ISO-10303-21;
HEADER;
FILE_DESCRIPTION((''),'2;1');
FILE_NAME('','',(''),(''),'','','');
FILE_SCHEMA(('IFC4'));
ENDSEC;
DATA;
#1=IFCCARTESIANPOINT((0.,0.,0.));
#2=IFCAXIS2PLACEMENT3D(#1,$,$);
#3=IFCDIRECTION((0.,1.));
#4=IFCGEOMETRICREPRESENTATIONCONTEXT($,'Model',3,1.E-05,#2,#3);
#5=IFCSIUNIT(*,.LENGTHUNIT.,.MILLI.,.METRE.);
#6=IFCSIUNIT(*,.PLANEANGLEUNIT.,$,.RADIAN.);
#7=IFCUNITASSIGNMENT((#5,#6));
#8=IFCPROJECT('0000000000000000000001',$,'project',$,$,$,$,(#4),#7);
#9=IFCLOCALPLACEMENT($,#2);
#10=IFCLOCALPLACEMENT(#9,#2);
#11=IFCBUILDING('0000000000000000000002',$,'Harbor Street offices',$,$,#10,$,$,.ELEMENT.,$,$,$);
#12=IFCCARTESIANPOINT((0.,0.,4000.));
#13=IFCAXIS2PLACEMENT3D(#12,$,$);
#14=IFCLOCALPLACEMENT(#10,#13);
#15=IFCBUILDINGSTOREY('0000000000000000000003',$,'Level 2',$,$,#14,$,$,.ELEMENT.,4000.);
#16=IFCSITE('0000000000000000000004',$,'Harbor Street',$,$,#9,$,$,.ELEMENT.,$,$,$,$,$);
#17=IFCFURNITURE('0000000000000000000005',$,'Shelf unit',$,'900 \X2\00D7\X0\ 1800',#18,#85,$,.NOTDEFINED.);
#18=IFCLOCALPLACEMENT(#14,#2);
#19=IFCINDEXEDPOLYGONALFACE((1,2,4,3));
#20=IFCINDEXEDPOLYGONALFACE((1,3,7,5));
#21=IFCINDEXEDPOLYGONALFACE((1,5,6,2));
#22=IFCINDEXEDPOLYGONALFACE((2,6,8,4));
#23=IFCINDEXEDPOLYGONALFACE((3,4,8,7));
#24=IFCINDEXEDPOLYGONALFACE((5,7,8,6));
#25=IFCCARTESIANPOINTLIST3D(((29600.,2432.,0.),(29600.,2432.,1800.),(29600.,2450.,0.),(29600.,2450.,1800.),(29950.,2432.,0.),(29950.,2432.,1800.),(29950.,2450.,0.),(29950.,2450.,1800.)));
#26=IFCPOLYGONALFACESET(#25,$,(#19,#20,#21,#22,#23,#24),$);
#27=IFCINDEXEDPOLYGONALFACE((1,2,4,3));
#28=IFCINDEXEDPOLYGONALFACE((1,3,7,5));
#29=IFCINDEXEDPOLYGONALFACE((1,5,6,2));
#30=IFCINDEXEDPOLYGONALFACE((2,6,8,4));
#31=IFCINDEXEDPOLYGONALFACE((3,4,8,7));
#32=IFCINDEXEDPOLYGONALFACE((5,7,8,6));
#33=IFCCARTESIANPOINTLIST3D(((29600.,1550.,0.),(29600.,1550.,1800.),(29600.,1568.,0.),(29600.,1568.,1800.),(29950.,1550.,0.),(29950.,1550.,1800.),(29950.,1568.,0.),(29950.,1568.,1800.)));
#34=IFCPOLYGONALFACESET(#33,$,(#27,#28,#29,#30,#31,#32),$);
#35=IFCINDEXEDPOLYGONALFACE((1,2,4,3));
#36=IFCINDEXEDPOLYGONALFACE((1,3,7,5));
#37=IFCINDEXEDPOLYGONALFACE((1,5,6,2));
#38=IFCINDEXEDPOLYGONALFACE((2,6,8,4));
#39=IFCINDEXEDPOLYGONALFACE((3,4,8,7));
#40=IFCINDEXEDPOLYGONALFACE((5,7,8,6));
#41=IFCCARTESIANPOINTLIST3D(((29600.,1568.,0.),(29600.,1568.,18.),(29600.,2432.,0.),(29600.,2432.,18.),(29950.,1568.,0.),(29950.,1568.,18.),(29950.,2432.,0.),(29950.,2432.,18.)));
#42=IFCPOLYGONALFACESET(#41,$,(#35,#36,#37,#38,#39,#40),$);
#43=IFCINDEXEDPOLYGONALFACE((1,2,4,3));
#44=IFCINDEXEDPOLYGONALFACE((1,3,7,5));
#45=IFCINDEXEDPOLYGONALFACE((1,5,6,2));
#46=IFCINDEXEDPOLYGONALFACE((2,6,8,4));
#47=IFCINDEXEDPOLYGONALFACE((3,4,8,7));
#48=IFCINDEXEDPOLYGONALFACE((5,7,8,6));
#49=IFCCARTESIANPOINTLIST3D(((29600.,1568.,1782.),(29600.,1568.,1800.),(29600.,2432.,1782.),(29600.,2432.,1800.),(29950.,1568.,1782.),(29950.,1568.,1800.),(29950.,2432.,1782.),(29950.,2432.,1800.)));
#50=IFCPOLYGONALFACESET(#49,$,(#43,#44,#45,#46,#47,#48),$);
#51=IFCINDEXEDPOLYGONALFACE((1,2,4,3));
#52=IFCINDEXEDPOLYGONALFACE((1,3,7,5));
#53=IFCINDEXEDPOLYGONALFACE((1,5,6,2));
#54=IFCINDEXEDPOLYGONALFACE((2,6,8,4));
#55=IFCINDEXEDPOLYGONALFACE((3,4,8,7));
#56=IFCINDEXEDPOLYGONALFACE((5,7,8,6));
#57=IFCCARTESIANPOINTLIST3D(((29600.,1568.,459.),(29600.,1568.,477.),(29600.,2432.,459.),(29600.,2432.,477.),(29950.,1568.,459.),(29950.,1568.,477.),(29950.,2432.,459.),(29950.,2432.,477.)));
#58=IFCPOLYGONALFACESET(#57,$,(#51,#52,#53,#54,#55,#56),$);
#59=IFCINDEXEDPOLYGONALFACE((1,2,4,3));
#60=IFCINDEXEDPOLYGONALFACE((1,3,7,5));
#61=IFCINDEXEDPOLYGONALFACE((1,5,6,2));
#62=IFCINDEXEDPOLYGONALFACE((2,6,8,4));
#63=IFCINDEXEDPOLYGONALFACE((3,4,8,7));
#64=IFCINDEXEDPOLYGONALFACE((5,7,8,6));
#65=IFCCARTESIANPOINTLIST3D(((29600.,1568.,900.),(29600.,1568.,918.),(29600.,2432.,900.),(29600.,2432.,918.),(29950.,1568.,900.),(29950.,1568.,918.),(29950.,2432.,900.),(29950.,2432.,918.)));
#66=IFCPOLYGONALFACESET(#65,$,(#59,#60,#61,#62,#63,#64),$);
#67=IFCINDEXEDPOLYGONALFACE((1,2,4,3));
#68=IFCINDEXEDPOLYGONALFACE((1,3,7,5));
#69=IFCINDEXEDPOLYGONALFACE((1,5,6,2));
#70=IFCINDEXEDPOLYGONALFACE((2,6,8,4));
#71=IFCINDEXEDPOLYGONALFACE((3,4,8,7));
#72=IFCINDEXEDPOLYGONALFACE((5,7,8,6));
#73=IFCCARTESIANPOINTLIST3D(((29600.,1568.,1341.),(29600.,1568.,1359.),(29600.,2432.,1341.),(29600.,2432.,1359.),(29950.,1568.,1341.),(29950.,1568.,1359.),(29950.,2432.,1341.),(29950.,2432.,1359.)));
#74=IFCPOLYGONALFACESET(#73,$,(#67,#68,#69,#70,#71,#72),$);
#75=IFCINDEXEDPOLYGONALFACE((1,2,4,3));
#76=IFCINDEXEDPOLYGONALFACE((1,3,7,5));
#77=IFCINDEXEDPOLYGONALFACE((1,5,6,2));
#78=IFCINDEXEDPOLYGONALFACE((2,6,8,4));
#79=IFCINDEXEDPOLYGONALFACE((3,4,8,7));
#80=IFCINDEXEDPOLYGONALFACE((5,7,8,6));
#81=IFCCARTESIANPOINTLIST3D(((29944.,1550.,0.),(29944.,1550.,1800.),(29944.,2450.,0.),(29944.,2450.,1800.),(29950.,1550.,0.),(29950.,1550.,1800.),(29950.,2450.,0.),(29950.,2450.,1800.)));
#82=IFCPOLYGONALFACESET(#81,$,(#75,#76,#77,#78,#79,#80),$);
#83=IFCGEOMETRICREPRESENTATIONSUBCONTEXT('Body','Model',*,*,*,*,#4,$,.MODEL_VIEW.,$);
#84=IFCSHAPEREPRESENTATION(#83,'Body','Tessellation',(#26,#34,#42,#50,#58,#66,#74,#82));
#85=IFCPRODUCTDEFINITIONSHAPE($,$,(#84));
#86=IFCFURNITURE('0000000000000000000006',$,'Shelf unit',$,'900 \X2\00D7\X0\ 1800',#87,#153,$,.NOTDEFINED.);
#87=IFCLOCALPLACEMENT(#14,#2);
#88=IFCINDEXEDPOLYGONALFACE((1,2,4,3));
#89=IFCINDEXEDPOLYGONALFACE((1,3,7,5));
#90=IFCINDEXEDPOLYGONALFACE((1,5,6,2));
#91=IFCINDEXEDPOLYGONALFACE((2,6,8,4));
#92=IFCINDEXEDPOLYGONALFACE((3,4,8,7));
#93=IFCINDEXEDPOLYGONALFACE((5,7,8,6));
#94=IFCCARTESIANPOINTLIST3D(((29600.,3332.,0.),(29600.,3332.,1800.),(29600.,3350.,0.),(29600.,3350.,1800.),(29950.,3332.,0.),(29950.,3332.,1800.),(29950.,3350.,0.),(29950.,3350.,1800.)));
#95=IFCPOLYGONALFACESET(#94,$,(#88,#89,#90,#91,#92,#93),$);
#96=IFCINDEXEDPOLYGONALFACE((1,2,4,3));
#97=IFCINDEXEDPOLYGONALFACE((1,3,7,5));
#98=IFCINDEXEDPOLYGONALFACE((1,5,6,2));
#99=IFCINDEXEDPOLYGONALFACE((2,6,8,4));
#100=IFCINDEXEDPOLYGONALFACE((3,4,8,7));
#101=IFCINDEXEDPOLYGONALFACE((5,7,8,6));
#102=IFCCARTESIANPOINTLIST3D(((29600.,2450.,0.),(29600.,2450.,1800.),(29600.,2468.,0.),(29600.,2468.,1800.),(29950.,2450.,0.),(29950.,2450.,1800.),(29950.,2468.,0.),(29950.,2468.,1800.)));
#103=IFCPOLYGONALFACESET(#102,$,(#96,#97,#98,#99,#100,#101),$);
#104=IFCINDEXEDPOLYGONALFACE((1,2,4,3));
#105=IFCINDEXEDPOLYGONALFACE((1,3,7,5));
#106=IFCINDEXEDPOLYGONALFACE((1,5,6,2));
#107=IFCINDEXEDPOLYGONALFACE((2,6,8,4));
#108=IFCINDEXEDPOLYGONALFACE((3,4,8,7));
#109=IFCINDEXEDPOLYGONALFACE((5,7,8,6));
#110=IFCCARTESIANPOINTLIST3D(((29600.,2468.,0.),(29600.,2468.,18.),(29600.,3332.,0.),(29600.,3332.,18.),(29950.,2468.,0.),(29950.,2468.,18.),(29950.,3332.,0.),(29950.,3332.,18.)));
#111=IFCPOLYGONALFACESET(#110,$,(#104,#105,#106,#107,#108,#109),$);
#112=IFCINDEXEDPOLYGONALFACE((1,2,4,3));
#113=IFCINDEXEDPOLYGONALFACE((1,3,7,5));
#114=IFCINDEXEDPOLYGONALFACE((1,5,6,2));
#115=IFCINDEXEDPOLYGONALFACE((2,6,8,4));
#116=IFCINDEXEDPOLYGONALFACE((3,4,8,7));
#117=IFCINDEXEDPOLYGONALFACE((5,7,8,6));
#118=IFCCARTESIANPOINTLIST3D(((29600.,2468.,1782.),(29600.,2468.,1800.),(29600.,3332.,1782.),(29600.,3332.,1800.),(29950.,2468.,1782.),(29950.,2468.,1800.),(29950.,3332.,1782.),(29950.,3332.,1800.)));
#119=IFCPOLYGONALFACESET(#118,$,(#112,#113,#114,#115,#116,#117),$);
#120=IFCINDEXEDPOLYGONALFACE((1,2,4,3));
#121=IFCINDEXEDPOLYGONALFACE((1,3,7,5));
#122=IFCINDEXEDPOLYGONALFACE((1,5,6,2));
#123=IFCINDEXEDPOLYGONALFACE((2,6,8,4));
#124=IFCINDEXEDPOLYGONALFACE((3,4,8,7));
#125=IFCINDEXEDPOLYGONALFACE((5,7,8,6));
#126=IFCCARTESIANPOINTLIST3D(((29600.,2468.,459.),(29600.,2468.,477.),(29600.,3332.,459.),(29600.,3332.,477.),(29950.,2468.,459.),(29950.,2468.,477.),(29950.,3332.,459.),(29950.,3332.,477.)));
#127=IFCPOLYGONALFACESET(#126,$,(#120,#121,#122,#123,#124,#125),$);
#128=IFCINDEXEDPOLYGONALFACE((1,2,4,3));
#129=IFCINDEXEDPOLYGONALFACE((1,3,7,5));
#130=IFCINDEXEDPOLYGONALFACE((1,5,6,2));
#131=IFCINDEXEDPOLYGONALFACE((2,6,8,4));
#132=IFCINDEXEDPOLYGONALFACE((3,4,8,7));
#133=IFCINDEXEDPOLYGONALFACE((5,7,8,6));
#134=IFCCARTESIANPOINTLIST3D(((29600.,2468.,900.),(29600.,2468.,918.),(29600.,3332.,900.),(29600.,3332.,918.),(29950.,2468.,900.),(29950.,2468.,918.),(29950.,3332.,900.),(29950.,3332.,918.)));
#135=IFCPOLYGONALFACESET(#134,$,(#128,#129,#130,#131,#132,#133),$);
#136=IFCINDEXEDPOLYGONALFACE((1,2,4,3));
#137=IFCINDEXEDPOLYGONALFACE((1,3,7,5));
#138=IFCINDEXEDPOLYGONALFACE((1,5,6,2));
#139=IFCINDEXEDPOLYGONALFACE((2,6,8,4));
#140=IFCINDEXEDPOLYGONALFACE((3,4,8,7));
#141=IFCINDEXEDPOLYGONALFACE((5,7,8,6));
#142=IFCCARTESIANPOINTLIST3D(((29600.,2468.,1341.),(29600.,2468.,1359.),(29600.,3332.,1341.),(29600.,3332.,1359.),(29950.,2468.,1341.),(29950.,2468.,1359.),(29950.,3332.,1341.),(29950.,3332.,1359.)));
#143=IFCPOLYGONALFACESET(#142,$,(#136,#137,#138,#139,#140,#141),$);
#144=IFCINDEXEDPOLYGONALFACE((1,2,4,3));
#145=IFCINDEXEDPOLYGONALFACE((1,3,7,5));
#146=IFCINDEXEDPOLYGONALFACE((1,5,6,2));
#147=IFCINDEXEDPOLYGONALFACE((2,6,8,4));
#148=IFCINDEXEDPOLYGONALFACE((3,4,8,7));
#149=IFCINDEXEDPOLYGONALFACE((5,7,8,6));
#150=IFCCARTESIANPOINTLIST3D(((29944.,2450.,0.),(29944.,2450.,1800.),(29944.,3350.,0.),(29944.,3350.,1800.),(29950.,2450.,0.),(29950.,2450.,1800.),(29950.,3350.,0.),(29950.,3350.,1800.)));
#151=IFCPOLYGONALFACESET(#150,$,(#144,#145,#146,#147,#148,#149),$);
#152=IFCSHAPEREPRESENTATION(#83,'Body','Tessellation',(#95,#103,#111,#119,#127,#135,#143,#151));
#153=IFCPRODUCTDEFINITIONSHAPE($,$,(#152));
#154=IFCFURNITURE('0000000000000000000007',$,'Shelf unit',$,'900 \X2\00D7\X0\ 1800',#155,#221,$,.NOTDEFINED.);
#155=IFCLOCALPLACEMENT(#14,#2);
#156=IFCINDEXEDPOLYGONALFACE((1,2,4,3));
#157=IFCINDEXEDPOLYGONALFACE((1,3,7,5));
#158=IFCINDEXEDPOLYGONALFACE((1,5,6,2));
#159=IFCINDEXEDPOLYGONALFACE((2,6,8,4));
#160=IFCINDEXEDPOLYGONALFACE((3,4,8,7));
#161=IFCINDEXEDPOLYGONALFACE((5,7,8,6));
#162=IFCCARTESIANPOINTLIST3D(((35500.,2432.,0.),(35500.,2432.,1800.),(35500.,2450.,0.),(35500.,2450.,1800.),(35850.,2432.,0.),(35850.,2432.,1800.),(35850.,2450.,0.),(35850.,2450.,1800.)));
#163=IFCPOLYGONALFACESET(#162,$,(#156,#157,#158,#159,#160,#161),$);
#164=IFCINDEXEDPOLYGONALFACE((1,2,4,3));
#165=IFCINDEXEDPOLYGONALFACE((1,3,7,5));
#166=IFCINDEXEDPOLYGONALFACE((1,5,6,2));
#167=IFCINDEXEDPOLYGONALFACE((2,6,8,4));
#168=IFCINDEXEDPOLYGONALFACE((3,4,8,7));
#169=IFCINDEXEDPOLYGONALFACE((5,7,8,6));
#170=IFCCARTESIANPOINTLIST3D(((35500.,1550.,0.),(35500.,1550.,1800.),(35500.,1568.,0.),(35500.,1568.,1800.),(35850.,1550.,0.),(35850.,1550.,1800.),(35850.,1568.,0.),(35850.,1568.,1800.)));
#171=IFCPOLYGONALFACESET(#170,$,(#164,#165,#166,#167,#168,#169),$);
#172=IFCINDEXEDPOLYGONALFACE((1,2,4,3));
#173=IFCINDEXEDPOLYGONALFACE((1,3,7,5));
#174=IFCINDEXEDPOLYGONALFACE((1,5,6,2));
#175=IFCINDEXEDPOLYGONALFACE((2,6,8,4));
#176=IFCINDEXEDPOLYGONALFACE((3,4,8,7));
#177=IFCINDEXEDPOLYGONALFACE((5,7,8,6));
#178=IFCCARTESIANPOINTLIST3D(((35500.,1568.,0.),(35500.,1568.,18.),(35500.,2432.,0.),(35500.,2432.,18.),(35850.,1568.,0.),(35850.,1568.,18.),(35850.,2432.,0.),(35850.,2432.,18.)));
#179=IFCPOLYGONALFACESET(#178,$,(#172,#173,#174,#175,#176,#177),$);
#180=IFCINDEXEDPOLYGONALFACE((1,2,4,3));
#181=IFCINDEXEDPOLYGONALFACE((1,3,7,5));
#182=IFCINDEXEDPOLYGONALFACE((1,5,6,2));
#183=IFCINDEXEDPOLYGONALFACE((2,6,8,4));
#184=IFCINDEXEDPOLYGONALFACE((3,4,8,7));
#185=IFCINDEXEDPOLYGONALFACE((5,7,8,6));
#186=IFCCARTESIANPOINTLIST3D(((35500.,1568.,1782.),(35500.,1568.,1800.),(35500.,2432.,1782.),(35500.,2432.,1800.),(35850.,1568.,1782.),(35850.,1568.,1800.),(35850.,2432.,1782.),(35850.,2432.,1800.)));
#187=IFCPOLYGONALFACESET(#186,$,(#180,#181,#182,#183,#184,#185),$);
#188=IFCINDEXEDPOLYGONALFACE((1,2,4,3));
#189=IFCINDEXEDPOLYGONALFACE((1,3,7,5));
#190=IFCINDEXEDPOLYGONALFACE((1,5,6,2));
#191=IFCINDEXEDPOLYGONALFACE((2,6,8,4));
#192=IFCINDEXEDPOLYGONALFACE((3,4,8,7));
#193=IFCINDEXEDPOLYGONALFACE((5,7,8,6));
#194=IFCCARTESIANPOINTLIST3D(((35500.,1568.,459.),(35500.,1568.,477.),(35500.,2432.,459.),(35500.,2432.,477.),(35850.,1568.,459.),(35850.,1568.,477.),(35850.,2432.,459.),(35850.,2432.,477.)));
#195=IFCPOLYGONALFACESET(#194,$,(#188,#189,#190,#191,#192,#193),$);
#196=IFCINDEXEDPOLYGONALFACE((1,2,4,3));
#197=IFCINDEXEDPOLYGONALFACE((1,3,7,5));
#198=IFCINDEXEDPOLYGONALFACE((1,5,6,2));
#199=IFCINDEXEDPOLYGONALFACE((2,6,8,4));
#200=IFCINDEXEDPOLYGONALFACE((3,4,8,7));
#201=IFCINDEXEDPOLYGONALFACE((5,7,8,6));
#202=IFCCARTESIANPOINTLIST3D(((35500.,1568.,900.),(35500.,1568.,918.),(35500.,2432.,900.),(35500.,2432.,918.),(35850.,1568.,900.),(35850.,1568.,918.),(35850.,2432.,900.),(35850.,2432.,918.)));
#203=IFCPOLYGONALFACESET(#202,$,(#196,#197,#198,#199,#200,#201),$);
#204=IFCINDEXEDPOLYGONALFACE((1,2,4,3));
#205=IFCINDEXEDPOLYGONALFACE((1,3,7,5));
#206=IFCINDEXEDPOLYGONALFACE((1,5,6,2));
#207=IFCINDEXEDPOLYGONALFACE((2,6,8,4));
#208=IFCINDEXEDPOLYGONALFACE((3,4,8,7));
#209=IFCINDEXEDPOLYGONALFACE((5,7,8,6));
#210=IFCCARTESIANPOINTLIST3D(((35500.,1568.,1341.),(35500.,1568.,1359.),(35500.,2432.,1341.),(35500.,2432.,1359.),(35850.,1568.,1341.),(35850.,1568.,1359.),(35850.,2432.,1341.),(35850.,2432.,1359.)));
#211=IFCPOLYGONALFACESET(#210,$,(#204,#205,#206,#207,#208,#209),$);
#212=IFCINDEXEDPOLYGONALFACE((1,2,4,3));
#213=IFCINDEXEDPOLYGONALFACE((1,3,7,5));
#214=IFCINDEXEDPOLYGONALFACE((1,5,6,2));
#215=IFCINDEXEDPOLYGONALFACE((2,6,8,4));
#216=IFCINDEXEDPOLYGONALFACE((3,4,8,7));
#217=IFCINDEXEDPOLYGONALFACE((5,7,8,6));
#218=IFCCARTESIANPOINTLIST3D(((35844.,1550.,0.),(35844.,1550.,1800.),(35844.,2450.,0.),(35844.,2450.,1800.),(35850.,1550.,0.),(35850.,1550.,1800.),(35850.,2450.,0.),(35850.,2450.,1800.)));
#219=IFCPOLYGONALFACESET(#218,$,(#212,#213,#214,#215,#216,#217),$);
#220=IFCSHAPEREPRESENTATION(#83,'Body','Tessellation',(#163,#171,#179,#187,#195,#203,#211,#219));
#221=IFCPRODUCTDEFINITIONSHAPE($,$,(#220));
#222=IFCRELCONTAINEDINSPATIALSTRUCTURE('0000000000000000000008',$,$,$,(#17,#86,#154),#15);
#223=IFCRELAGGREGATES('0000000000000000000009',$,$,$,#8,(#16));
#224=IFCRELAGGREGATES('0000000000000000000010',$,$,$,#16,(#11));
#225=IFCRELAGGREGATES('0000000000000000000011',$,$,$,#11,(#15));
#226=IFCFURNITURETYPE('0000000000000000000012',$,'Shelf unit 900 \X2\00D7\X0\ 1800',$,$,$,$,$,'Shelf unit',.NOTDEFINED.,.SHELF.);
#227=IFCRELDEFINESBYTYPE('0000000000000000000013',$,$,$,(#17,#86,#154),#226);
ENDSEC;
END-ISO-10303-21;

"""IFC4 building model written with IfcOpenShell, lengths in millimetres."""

from ifc_helpers import new_model, si_unit, direction, frame, origin, place, context, subcontext, project, spatial, polyline, outline, extrude, source, transform, mapped, type_object, type_shapes, element, save


model = new_model("IFC4")

# Units and contexts
model_context = context("Model", 3, precision=1e-05, world=origin(), true_north=direction((0.0, 1.0)))
body_context = subcontext(model_context, "Body", "Model", "MODEL_VIEW")
ifc_project = project(units=[si_unit("LENGTHUNIT", "METRE", prefix="MILLI"), si_unit("PLANEANGLEUNIT", "RADIAN")], contexts=[model_context])

# Site, building, storey
site_placement = place(None, origin())
site = spatial("IfcSite", under=ifc_project, at=site_placement, Name="Harbor Street", CompositionType="ELEMENT")
building_placement = place(site_placement, origin())
building = spatial("IfcBuilding", under=site, at=building_placement, Name="Harbor Street offices", CompositionType="ELEMENT")
storey_placement = place(building_placement, frame((0.0, 0.0, 4000.0)))
storey = spatial("IfcBuildingStorey", under=building, at=storey_placement, Name="Level 2", CompositionType="ELEMENT", Elevation=4000.0)

# Furniture
furniture_type_1 = type_object("IfcFurnitureType", Name="Shelf unit 900 × 1800", ElementType="Shelf unit", AssemblyPlace="NOTDEFINED", PredefinedType="SHELF")
shared_shape_1 = source(origin(), body_context, "Body", "SweptSolid", [
    extrude(outline(polyline([(-450.0, 0.0), (-432.0, 0.0), (-432.0, 350.0), (-450.0, 350.0), (-450.0, 0.0)])), origin(), (0.0, 0.0, 1.0), 1800.0),
    extrude(outline(polyline([(432.0, 0.0), (450.0, 0.0), (450.0, 350.0), (432.0, 350.0), (432.0, 0.0)])), origin(), (0.0, 0.0, 1.0), 1800.0),
    extrude(outline(polyline([(-432.0, 0.0), (432.0, 0.0), (432.0, 350.0), (-432.0, 350.0), (-432.0, 0.0)])), origin(), (0.0, 0.0, 1.0), 18.0),
    extrude(outline(polyline([(-432.0, 0.0), (432.0, 0.0), (432.0, 350.0), (-432.0, 350.0), (-432.0, 0.0)])), frame((0.0, 0.0, 1782.0)), (0.0, 0.0, 1.0), 18.0),
    extrude(outline(polyline([(-432.0, 0.0), (432.0, 0.0), (432.0, 350.0), (-432.0, 350.0), (-432.0, 0.0)])), frame((0.0, 0.0, 459.0)), (0.0, 0.0, 1.0), 18.0),
    extrude(outline(polyline([(-432.0, 0.0), (432.0, 0.0), (432.0, 350.0), (-432.0, 350.0), (-432.0, 0.0)])), frame((0.0, 0.0, 900.0)), (0.0, 0.0, 1.0), 18.0),
    extrude(outline(polyline([(-432.0, 0.0), (432.0, 0.0), (432.0, 350.0), (-432.0, 350.0), (-432.0, 0.0)])), frame((0.0, 0.0, 1341.0)), (0.0, 0.0, 1.0), 18.0),
    extrude(outline(polyline([(-450.0, 344.0), (450.0, 344.0), (450.0, 350.0), (-450.0, 350.0), (-450.0, 344.0)])), origin(), (0.0, 0.0, 1.0), 1800.0),
])
type_shapes(furniture_type_1, [shared_shape_1])
for number, where, z_axis, x_axis, name in (
    (1, (29600.0, 2000.0, 0.0), (0.0, 0.0, 1.0), (0.0, -1.0, 0.0), "Shelf unit"),
    (2, (29600.0, 2900.0, 0.0), (0.0, 0.0, 1.0), (0.0, -1.0, 0.0), "Shelf unit"),
    (3, (35500.0, 2000.0, 0.0), (0.0, 0.0, 1.0), (0.0, -1.0, 0.0), "Shelf unit"),
):
    element("IfcFurniture", number, at=place(storey_placement, frame(where, z_axis=z_axis, x_axis=x_axis)), inside=storey, type_object=furniture_type_1, Name=name, ObjectType="900 × 1800", PredefinedType="NOTDEFINED", context=body_context, shape_type="MappedRepresentation", body=[
        mapped(shared_shape_1, transform((0.0, 0.0, 0.0))),
    ])

save(model, "model.ifc")
